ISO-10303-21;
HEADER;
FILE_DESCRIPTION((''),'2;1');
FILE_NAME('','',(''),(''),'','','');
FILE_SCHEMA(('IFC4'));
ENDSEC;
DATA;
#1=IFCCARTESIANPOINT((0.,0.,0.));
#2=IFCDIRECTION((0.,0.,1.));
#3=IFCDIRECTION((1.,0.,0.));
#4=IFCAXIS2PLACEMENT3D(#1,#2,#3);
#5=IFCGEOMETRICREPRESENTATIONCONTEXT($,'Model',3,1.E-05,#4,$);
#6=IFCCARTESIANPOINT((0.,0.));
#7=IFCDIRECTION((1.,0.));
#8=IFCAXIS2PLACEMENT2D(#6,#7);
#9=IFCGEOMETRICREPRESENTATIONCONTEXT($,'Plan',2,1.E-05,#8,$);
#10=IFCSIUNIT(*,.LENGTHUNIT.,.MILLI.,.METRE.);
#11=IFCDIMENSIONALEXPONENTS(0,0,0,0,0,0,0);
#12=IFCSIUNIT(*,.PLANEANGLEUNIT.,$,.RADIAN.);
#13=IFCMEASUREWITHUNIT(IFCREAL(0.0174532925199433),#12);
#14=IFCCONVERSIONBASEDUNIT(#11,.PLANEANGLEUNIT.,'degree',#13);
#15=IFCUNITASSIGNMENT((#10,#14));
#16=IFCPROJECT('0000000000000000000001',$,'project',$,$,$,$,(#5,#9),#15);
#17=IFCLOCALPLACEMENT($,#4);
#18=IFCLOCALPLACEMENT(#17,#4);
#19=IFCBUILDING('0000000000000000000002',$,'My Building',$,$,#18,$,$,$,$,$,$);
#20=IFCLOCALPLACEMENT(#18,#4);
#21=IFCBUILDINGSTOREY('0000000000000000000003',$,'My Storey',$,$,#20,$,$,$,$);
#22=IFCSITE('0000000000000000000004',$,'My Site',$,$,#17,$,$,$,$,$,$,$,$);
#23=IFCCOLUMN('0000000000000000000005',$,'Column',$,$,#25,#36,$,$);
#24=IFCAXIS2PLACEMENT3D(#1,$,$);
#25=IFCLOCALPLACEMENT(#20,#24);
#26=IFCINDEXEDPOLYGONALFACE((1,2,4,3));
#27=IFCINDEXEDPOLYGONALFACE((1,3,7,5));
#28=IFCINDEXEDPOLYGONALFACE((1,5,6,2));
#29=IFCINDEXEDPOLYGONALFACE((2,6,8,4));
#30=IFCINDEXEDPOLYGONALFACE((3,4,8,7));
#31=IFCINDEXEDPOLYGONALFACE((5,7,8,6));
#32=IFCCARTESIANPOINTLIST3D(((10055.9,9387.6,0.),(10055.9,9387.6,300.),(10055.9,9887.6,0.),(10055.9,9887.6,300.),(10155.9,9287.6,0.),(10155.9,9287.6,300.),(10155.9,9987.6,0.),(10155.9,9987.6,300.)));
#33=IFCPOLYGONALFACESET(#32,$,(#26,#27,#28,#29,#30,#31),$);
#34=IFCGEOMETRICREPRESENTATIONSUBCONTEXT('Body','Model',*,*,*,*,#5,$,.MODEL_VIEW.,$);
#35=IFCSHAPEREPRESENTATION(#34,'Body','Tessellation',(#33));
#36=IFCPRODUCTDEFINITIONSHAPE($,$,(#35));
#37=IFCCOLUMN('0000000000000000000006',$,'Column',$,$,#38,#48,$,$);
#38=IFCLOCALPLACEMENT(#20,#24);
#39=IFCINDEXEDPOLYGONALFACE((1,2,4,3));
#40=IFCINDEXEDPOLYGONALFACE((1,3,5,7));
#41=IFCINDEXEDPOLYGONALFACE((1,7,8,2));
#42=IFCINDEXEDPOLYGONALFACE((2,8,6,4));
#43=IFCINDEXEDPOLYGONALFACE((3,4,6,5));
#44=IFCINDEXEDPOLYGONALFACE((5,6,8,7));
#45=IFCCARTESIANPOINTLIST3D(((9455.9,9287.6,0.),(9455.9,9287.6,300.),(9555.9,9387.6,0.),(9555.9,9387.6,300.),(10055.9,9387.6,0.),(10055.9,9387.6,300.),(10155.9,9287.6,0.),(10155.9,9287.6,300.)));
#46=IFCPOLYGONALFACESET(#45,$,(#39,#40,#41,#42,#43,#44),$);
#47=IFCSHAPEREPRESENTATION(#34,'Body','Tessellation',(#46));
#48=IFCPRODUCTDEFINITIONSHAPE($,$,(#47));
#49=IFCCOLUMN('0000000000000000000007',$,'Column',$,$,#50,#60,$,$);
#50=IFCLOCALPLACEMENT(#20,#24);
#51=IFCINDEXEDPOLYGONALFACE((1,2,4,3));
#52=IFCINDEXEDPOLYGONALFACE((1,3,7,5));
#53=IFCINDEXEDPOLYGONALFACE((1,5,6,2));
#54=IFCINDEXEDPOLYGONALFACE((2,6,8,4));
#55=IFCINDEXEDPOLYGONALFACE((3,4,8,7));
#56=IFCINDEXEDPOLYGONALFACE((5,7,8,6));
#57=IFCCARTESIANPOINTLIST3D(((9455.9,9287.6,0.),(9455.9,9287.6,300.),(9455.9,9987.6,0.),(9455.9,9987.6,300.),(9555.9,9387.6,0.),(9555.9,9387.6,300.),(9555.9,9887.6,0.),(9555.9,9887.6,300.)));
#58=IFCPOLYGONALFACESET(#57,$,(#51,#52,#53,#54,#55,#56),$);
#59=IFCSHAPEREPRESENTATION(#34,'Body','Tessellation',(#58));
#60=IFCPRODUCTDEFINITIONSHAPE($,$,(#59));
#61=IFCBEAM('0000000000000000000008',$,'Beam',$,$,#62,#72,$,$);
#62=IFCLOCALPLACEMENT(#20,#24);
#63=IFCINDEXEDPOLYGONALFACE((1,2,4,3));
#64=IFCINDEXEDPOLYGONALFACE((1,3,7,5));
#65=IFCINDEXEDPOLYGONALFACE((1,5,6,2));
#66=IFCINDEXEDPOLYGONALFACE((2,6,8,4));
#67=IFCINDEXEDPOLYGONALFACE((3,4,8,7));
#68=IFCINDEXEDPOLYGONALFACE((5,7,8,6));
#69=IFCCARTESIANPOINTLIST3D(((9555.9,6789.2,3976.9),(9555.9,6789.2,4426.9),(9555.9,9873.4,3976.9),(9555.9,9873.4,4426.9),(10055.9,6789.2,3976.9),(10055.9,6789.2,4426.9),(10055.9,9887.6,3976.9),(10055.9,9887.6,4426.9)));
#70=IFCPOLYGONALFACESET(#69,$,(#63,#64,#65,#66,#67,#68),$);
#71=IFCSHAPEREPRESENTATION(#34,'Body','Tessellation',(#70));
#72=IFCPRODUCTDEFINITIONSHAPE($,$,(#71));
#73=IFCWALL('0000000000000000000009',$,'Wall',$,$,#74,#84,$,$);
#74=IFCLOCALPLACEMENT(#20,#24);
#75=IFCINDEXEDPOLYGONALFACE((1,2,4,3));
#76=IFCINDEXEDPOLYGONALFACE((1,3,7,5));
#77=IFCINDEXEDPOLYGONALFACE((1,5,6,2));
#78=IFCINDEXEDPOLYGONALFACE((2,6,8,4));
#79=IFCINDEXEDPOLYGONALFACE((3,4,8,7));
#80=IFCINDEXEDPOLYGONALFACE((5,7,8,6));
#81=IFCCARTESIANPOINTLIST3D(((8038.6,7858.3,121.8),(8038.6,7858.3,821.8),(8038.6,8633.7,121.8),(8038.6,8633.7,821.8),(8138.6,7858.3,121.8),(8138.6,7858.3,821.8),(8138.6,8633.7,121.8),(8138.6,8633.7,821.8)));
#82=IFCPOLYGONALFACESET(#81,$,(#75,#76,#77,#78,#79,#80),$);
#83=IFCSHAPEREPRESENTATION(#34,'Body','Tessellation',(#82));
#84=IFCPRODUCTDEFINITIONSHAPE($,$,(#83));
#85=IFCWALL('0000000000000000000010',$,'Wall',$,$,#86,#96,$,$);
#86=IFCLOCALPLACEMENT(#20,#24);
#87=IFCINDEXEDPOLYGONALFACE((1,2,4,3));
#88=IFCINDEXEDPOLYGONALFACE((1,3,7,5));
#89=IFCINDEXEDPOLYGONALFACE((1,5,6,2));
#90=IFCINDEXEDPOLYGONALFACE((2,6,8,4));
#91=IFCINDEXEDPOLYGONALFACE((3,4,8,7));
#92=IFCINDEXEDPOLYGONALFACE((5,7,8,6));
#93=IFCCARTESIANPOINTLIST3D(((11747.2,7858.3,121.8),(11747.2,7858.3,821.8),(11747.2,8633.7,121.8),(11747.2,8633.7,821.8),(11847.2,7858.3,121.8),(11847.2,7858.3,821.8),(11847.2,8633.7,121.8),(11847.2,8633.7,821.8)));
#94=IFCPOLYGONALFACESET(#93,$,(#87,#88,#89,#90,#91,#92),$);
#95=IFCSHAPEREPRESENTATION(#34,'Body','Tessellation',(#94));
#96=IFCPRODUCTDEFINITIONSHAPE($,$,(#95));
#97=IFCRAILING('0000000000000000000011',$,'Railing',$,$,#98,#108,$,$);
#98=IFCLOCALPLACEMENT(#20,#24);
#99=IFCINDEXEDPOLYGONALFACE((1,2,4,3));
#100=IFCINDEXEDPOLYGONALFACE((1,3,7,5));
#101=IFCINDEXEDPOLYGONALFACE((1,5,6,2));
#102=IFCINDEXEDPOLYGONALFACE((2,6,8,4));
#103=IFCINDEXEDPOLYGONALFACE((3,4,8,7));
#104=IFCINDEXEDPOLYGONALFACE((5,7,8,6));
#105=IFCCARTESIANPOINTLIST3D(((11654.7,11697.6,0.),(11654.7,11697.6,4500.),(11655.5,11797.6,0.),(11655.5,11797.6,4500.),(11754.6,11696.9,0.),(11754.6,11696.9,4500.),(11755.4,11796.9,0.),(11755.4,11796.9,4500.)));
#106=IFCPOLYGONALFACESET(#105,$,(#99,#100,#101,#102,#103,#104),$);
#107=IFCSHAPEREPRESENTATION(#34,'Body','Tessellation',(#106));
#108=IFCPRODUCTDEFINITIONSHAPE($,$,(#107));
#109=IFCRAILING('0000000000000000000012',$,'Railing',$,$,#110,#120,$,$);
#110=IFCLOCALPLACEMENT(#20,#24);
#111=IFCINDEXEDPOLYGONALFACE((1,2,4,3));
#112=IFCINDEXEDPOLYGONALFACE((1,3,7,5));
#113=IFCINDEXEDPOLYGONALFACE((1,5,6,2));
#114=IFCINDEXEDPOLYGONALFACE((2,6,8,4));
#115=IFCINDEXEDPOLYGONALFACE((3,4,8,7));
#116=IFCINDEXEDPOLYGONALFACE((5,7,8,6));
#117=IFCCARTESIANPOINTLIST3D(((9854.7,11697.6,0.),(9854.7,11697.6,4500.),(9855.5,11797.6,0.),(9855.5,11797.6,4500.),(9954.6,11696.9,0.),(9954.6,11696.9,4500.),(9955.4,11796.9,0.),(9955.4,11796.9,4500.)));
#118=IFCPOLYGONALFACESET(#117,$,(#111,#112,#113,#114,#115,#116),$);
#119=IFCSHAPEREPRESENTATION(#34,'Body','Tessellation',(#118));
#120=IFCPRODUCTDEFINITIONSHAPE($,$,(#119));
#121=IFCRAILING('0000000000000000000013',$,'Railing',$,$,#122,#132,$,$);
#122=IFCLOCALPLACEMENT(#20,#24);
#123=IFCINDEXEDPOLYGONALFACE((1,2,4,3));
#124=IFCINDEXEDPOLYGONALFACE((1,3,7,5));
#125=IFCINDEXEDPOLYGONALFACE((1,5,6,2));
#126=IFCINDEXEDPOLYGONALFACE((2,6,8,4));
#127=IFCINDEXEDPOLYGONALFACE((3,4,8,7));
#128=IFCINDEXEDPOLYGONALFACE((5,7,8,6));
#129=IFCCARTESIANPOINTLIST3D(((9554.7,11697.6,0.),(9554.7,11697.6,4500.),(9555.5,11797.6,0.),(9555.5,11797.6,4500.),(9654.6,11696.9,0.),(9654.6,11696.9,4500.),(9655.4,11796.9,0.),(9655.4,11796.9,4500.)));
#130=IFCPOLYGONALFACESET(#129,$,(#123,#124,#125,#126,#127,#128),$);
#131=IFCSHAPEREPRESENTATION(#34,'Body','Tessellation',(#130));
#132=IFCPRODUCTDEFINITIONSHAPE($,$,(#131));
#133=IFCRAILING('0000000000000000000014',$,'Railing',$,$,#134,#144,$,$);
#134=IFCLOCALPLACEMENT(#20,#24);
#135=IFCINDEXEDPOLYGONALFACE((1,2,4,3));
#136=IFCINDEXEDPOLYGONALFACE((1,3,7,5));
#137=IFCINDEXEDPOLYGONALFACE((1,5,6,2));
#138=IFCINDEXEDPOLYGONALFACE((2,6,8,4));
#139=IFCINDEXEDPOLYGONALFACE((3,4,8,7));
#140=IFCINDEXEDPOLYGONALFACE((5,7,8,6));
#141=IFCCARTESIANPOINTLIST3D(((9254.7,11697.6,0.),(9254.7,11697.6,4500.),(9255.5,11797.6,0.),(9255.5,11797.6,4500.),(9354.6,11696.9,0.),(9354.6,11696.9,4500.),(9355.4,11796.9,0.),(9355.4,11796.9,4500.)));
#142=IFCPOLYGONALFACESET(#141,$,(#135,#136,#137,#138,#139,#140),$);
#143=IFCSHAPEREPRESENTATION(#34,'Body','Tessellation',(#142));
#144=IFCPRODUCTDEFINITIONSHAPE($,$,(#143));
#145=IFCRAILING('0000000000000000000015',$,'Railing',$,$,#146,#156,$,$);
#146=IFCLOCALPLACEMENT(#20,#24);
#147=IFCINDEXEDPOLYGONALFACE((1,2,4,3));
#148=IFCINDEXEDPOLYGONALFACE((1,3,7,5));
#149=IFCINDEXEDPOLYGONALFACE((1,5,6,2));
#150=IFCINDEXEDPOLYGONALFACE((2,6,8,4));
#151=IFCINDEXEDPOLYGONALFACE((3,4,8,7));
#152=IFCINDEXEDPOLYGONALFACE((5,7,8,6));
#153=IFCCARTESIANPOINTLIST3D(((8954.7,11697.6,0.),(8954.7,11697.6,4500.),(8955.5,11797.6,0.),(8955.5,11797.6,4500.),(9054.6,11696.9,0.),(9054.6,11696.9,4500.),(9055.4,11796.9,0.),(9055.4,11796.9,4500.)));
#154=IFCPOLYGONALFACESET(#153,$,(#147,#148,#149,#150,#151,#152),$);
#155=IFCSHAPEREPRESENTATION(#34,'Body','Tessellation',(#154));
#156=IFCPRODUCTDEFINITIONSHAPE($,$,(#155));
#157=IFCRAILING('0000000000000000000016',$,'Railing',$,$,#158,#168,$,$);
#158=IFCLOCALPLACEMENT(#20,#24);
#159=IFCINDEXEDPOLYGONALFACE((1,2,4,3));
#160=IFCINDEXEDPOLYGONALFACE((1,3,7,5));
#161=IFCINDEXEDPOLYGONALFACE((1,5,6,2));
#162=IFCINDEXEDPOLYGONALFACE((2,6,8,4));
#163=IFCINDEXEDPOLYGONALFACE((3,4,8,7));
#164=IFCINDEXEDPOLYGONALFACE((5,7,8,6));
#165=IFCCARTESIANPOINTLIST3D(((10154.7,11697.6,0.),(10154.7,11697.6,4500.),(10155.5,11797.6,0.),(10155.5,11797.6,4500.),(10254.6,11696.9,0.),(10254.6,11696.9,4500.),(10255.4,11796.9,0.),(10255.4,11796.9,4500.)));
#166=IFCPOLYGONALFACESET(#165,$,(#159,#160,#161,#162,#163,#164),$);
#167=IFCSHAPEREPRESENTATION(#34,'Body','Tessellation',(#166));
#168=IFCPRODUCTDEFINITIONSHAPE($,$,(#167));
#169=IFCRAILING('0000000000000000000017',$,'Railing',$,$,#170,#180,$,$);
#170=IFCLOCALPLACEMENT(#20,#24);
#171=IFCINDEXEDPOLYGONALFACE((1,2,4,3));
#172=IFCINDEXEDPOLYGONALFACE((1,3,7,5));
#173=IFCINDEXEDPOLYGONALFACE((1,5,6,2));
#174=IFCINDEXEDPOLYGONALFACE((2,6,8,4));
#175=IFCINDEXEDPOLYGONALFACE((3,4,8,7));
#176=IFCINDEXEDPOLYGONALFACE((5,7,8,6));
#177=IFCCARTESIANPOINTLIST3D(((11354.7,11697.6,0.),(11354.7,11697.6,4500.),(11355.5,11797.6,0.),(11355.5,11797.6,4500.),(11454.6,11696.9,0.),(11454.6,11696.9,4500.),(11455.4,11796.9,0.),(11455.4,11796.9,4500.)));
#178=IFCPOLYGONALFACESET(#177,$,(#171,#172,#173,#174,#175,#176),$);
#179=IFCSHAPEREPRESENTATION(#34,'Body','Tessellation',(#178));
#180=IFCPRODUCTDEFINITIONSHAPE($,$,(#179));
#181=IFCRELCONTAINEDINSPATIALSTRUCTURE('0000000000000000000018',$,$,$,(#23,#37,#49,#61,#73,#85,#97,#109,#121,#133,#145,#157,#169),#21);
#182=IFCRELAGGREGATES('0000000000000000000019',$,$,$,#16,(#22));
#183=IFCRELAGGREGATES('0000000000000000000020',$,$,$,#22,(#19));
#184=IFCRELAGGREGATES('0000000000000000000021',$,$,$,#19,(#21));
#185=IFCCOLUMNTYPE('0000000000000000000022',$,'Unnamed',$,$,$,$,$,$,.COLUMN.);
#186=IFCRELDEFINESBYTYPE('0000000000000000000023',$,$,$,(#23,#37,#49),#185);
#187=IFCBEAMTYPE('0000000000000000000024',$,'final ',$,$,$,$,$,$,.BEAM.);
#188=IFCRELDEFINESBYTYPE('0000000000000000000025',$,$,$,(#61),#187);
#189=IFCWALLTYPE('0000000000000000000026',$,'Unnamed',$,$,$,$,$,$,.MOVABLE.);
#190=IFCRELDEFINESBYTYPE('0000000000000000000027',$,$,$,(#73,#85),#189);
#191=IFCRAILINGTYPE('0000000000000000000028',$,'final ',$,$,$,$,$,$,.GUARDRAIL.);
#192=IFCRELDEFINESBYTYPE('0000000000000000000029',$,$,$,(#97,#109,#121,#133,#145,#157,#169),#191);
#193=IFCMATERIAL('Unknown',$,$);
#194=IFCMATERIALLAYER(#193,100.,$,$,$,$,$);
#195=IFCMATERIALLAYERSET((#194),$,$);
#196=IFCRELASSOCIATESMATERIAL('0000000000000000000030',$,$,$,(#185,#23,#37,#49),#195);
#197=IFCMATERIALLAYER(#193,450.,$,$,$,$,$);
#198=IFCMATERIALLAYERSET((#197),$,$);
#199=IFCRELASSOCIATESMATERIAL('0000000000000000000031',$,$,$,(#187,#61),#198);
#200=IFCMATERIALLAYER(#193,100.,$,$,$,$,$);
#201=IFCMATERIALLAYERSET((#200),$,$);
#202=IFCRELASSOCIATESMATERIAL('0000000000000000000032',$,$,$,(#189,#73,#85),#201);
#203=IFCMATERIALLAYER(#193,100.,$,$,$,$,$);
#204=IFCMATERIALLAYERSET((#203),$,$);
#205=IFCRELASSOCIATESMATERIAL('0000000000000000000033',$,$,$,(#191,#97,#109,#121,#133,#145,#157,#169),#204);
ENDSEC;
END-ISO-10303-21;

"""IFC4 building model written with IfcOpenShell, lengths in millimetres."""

from ifc_helpers import new_model, entity, si_unit, converted_unit, frame, origin_with_axes, origin_2d_with_axis, place, context, subcontext, project, spatial, line, indexed_curve, outline, extrude, material, layer, layer_set, layer_usage, type_object, element, save


model = new_model("IFC4")

# Units and contexts
model_context = context("Model", 3, precision=1e-05, world=origin_with_axes())
plan_context = context("Plan", 2, precision=1e-05, world=origin_2d_with_axis())
body_context = subcontext(model_context, "Body", "Model", "MODEL_VIEW")
ifc_project = project(units=[si_unit("LENGTHUNIT", "METRE", prefix="MILLI"), converted_unit("PLANEANGLEUNIT", "degree", entity("IfcReal", 0.0174532925199433), si_unit("PLANEANGLEUNIT", "RADIAN"), dimensions=[0, 0, 0, 0, 0, 0, 0])], contexts=[model_context, plan_context])

# Site, building, storey
site_placement = place(None, origin_with_axes())
site = spatial("IfcSite", under=ifc_project, at=site_placement, Name="My Site")
building_placement = place(site_placement, origin_with_axes())
building = spatial("IfcBuilding", under=site, at=building_placement, Name="My Building")
storey_placement = place(building_placement, origin_with_axes())
storey = spatial("IfcBuildingStorey", under=building, at=storey_placement, Name="My Storey")

# Columns
ifc_material = material(Name="Unknown")
ifc_layer_1 = layer(ifc_material, 100.0)
ifc_layer_set_1 = layer_set([ifc_layer_1])
column_type = type_object("IfcColumnType", Name="Unnamed", PredefinedType="COLUMN", material=ifc_layer_set_1)
ifc_layer_usage_1 = layer_usage(ifc_layer_set_1, "AXIS2", "POSITIVE", 0.0)
column_1_placement = place(storey_placement, frame((10055.9, 9887.6, 0.0), z_axis=(0.0, 0.0, 1.0), x_axis=(0.000002, -1.0, 0.0)))
element("IfcColumn", 1, at=column_1_placement, inside=storey, type_object=column_type, material=ifc_layer_usage_1, Name="Column", context=body_context, shape_type="SweptSolid", body=[
    extrude(outline(indexed_curve([(0.0, 0.0), (-100.0, 100.0), (600.0, 100.0), (500.0, 0.0)], segments=[line(1, 2, 3, 4, 1)])), origin_with_axes(), (0.0, 0.0, 1.0), 300.0),
])
ifc_layer_usage_2 = layer_usage(ifc_layer_set_1, "AXIS2", "POSITIVE", 0.0)
column_2_placement = place(storey_placement, frame((10055.9, 9387.6, 0.0), z_axis=(0.0, 0.0, 1.0), x_axis=(-1.0, 0.0, 0.0)))
element("IfcColumn", 2, at=column_2_placement, inside=storey, type_object=column_type, material=ifc_layer_usage_2, Name="Column", context=body_context, shape_type="SweptSolid", body=[
    extrude(outline(indexed_curve([(0.0, 0.0), (-100.0, 100.0), (600.0, 100.0), (500.0, 0.0)], segments=[line(1, 2, 3, 4, 1)])), origin_with_axes(), (0.0, 0.0, 1.0), 300.0),
])
ifc_layer_usage_3 = layer_usage(ifc_layer_set_1, "AXIS2", "POSITIVE", 0.0)
column_3_placement = place(storey_placement, frame((9555.9, 9387.6, 0.0), z_axis=(0.0, 0.0, 1.0), x_axis=(-0.000002, 1.0, 0.0)))
element("IfcColumn", 3, at=column_3_placement, inside=storey, type_object=column_type, material=ifc_layer_usage_3, Name="Column", context=body_context, shape_type="SweptSolid", body=[
    extrude(outline(indexed_curve([(0.0, 0.0), (-100.0, 100.0), (600.0, 100.0), (500.0, 0.0)], segments=[line(1, 2, 3, 4, 1)])), origin_with_axes(), (0.0, 0.0, 1.0), 300.0),
])

# Beam
ifc_layer_2 = layer(ifc_material, 450.0)
ifc_layer_set_2 = layer_set([ifc_layer_2])
ifc_layer_usage_4 = layer_usage(ifc_layer_set_2, "AXIS3", "POSITIVE", -450.0)
beam_type = type_object("IfcBeamType", Name="final ", PredefinedType="BEAM", material=ifc_layer_set_2)
beam_placement = place(storey_placement, frame((10055.9, 9887.6, 4426.9), z_axis=(0.0, 0.0, 1.0), x_axis=(1.0, 0.0, 0.0)))
element("IfcBeam", 4, at=beam_placement, inside=storey, type_object=beam_type, material=ifc_layer_usage_4, Name="Beam", context=body_context, shape_type="SweptSolid", body=[
    extrude(outline(indexed_curve([(0.0, 0.0), (0.0, -3098.3), (-500.0, -3098.3), (-500.0, -14.2), (0.0, 0.0)])), frame((0.0, 0.0, -450.0), z_axis=(0.0, 0.0, 1.0), x_axis=(1.0, 0.0, 0.0)), (0.0, 0.0, 1.0), 450.0),
])

# Walls
ifc_layer_3 = layer(ifc_material, 100.0)
ifc_layer_set_3 = layer_set([ifc_layer_3])
ifc_layer_usage_5 = layer_usage(ifc_layer_set_3, "AXIS2", "POSITIVE", 0.0)
wall_type = type_object("IfcWallType", Name="Unnamed", PredefinedType="MOVABLE", material=ifc_layer_set_3)
wall_1_placement = place(storey_placement, frame((8038.6, 8633.7, 121.8), z_axis=(0.0, 0.0, 1.0), x_axis=(0.0, -1.0, 0.0)))
element("IfcWall", 5, at=wall_1_placement, inside=storey, type_object=wall_type, material=ifc_layer_usage_5, Name="Wall", context=body_context, shape_type="SweptSolid", body=[
    extrude(outline(indexed_curve([(0.0, 0.0), (0.0, 100.0), (775.4, 100.0), (775.4, 0.0)], segments=[line(1, 2, 3, 4, 1)])), origin_with_axes(), (0.0, 0.0, 1.0), 700.0),
])
ifc_layer_usage_6 = layer_usage(ifc_layer_set_3, "AXIS2", "POSITIVE", 0.0)
wall_2_placement = place(storey_placement, frame((11747.2, 8633.7, 121.8), z_axis=(0.0, 0.0, 1.0), x_axis=(0.0, -1.0, 0.0)))
element("IfcWall", 6, at=wall_2_placement, inside=storey, type_object=wall_type, material=ifc_layer_usage_6, Name="Wall", context=body_context, shape_type="SweptSolid", body=[
    extrude(outline(indexed_curve([(0.0, 0.0), (0.0, 100.0), (775.4, 100.0), (775.4, 0.0)], segments=[line(1, 2, 3, 4, 1)])), origin_with_axes(), (0.0, 0.0, 1.0), 700.0),
])

# Railings
ifc_layer_4 = layer(ifc_material, 100.0)
ifc_layer_set_4 = layer_set([ifc_layer_4])
ifc_layer_usage_7 = layer_usage(ifc_layer_set_4, "AXIS2", "POSITIVE", 0.0)
railing_type = type_object("IfcRailingType", Name="final ", PredefinedType="GUARDRAIL", material=ifc_layer_set_4)
railing_1_placement = place(storey_placement, frame((11755.4, 11796.9, 0.0), z_axis=(0.0, 0.0, 1.0), x_axis=(-0.99997, 0.007689, 0.0)))
element("IfcRailing", 7, at=railing_1_placement, inside=storey, type_object=railing_type, material=ifc_layer_usage_7, Name="Railing", context=body_context, shape_type="SweptSolid", body=[
    extrude(outline(indexed_curve([(0.0, 0.0), (0.0, 100.0), (99.8, 100.0), (99.8, 0.0)], segments=[line(1, 2, 3, 4, 1)])), origin_with_axes(), (0.0, 0.0, 1.0), 4500.0),
])
ifc_layer_usage_8 = layer_usage(ifc_layer_set_4, "AXIS2", "POSITIVE", 0.0)
railing_2_placement = place(storey_placement, frame((9955.4, 11796.9, 0.0), z_axis=(0.0, 0.0, 1.0), x_axis=(-0.99997, 0.007689, 0.0)))
element("IfcRailing", 8, at=railing_2_placement, inside=storey, type_object=railing_type, material=ifc_layer_usage_8, Name="Railing", context=body_context, shape_type="SweptSolid", body=[
    extrude(outline(indexed_curve([(0.0, 0.0), (0.0, 100.0), (99.8, 100.0), (99.8, 0.0)], segments=[line(1, 2, 3, 4, 1)])), origin_with_axes(), (0.0, 0.0, 1.0), 4500.0),
])
ifc_layer_usage_9 = layer_usage(ifc_layer_set_4, "AXIS2", "POSITIVE", 0.0)
railing_3_placement = place(storey_placement, frame((9655.4, 11796.9, 0.0), z_axis=(0.0, 0.0, 1.0), x_axis=(-0.99997, 0.007689, 0.0)))
element("IfcRailing", 9, at=railing_3_placement, inside=storey, type_object=railing_type, material=ifc_layer_usage_9, Name="Railing", context=body_context, shape_type="SweptSolid", body=[
    extrude(outline(indexed_curve([(0.0, 0.0), (0.0, 100.0), (99.8, 100.0), (99.8, 0.0)], segments=[line(1, 2, 3, 4, 1)])), origin_with_axes(), (0.0, 0.0, 1.0), 4500.0),
])
ifc_layer_usage_10 = layer_usage(ifc_layer_set_4, "AXIS2", "POSITIVE", 0.0)
railing_4_placement = place(storey_placement, frame((9355.4, 11796.9, 0.0), z_axis=(0.0, 0.0, 1.0), x_axis=(-0.99997, 0.007689, 0.0)))
element("IfcRailing", 10, at=railing_4_placement, inside=storey, type_object=railing_type, material=ifc_layer_usage_10, Name="Railing", context=body_context, shape_type="SweptSolid", body=[
    extrude(outline(indexed_curve([(0.0, 0.0), (0.0, 100.0), (99.8, 100.0), (99.8, 0.0)], segments=[line(1, 2, 3, 4, 1)])), origin_with_axes(), (0.0, 0.0, 1.0), 4500.0),
])
ifc_layer_usage_11 = layer_usage(ifc_layer_set_4, "AXIS2", "POSITIVE", 0.0)
railing_5_placement = place(storey_placement, frame((9055.4, 11796.9, 0.0), z_axis=(0.0, 0.0, 1.0), x_axis=(-0.99997, 0.007689, 0.0)))
element("IfcRailing", 11, at=railing_5_placement, inside=storey, type_object=railing_type, material=ifc_layer_usage_11, Name="Railing", context=body_context, shape_type="SweptSolid", body=[
    extrude(outline(indexed_curve([(0.0, 0.0), (0.0, 100.0), (99.8, 100.0), (99.8, 0.0)], segments=[line(1, 2, 3, 4, 1)])), origin_with_axes(), (0.0, 0.0, 1.0), 4500.0),
])
ifc_layer_usage_12 = layer_usage(ifc_layer_set_4, "AXIS2", "POSITIVE", 0.0)
railing_6_placement = place(storey_placement, frame((10255.4, 11796.9, 0.0), z_axis=(0.0, 0.0, 1.0), x_axis=(-0.99997, 0.007689, 0.0)))
element("IfcRailing", 12, at=railing_6_placement, inside=storey, type_object=railing_type, material=ifc_layer_usage_12, Name="Railing", context=body_context, shape_type="SweptSolid", body=[
    extrude(outline(indexed_curve([(0.0, 0.0), (0.0, 100.0), (99.8, 100.0), (99.8, 0.0)], segments=[line(1, 2, 3, 4, 1)])), origin_with_axes(), (0.0, 0.0, 1.0), 4500.0),
])
ifc_layer_usage_13 = layer_usage(ifc_layer_set_4, "AXIS2", "POSITIVE", 0.0)
railing_7_placement = place(storey_placement, frame((11455.4, 11796.9, 0.0), z_axis=(0.0, 0.0, 1.0), x_axis=(-0.99997, 0.007689, 0.0)))
element("IfcRailing", 13, at=railing_7_placement, inside=storey, type_object=railing_type, material=ifc_layer_usage_13, Name="Railing", context=body_context, shape_type="SweptSolid", body=[
    extrude(outline(indexed_curve([(0.0, 0.0), (0.0, 100.0), (99.8, 100.0), (99.8, 0.0)], segments=[line(1, 2, 3, 4, 1)])), origin_with_axes(), (0.0, 0.0, 1.0), 4500.0),
])

save(model, "model.ifc")
